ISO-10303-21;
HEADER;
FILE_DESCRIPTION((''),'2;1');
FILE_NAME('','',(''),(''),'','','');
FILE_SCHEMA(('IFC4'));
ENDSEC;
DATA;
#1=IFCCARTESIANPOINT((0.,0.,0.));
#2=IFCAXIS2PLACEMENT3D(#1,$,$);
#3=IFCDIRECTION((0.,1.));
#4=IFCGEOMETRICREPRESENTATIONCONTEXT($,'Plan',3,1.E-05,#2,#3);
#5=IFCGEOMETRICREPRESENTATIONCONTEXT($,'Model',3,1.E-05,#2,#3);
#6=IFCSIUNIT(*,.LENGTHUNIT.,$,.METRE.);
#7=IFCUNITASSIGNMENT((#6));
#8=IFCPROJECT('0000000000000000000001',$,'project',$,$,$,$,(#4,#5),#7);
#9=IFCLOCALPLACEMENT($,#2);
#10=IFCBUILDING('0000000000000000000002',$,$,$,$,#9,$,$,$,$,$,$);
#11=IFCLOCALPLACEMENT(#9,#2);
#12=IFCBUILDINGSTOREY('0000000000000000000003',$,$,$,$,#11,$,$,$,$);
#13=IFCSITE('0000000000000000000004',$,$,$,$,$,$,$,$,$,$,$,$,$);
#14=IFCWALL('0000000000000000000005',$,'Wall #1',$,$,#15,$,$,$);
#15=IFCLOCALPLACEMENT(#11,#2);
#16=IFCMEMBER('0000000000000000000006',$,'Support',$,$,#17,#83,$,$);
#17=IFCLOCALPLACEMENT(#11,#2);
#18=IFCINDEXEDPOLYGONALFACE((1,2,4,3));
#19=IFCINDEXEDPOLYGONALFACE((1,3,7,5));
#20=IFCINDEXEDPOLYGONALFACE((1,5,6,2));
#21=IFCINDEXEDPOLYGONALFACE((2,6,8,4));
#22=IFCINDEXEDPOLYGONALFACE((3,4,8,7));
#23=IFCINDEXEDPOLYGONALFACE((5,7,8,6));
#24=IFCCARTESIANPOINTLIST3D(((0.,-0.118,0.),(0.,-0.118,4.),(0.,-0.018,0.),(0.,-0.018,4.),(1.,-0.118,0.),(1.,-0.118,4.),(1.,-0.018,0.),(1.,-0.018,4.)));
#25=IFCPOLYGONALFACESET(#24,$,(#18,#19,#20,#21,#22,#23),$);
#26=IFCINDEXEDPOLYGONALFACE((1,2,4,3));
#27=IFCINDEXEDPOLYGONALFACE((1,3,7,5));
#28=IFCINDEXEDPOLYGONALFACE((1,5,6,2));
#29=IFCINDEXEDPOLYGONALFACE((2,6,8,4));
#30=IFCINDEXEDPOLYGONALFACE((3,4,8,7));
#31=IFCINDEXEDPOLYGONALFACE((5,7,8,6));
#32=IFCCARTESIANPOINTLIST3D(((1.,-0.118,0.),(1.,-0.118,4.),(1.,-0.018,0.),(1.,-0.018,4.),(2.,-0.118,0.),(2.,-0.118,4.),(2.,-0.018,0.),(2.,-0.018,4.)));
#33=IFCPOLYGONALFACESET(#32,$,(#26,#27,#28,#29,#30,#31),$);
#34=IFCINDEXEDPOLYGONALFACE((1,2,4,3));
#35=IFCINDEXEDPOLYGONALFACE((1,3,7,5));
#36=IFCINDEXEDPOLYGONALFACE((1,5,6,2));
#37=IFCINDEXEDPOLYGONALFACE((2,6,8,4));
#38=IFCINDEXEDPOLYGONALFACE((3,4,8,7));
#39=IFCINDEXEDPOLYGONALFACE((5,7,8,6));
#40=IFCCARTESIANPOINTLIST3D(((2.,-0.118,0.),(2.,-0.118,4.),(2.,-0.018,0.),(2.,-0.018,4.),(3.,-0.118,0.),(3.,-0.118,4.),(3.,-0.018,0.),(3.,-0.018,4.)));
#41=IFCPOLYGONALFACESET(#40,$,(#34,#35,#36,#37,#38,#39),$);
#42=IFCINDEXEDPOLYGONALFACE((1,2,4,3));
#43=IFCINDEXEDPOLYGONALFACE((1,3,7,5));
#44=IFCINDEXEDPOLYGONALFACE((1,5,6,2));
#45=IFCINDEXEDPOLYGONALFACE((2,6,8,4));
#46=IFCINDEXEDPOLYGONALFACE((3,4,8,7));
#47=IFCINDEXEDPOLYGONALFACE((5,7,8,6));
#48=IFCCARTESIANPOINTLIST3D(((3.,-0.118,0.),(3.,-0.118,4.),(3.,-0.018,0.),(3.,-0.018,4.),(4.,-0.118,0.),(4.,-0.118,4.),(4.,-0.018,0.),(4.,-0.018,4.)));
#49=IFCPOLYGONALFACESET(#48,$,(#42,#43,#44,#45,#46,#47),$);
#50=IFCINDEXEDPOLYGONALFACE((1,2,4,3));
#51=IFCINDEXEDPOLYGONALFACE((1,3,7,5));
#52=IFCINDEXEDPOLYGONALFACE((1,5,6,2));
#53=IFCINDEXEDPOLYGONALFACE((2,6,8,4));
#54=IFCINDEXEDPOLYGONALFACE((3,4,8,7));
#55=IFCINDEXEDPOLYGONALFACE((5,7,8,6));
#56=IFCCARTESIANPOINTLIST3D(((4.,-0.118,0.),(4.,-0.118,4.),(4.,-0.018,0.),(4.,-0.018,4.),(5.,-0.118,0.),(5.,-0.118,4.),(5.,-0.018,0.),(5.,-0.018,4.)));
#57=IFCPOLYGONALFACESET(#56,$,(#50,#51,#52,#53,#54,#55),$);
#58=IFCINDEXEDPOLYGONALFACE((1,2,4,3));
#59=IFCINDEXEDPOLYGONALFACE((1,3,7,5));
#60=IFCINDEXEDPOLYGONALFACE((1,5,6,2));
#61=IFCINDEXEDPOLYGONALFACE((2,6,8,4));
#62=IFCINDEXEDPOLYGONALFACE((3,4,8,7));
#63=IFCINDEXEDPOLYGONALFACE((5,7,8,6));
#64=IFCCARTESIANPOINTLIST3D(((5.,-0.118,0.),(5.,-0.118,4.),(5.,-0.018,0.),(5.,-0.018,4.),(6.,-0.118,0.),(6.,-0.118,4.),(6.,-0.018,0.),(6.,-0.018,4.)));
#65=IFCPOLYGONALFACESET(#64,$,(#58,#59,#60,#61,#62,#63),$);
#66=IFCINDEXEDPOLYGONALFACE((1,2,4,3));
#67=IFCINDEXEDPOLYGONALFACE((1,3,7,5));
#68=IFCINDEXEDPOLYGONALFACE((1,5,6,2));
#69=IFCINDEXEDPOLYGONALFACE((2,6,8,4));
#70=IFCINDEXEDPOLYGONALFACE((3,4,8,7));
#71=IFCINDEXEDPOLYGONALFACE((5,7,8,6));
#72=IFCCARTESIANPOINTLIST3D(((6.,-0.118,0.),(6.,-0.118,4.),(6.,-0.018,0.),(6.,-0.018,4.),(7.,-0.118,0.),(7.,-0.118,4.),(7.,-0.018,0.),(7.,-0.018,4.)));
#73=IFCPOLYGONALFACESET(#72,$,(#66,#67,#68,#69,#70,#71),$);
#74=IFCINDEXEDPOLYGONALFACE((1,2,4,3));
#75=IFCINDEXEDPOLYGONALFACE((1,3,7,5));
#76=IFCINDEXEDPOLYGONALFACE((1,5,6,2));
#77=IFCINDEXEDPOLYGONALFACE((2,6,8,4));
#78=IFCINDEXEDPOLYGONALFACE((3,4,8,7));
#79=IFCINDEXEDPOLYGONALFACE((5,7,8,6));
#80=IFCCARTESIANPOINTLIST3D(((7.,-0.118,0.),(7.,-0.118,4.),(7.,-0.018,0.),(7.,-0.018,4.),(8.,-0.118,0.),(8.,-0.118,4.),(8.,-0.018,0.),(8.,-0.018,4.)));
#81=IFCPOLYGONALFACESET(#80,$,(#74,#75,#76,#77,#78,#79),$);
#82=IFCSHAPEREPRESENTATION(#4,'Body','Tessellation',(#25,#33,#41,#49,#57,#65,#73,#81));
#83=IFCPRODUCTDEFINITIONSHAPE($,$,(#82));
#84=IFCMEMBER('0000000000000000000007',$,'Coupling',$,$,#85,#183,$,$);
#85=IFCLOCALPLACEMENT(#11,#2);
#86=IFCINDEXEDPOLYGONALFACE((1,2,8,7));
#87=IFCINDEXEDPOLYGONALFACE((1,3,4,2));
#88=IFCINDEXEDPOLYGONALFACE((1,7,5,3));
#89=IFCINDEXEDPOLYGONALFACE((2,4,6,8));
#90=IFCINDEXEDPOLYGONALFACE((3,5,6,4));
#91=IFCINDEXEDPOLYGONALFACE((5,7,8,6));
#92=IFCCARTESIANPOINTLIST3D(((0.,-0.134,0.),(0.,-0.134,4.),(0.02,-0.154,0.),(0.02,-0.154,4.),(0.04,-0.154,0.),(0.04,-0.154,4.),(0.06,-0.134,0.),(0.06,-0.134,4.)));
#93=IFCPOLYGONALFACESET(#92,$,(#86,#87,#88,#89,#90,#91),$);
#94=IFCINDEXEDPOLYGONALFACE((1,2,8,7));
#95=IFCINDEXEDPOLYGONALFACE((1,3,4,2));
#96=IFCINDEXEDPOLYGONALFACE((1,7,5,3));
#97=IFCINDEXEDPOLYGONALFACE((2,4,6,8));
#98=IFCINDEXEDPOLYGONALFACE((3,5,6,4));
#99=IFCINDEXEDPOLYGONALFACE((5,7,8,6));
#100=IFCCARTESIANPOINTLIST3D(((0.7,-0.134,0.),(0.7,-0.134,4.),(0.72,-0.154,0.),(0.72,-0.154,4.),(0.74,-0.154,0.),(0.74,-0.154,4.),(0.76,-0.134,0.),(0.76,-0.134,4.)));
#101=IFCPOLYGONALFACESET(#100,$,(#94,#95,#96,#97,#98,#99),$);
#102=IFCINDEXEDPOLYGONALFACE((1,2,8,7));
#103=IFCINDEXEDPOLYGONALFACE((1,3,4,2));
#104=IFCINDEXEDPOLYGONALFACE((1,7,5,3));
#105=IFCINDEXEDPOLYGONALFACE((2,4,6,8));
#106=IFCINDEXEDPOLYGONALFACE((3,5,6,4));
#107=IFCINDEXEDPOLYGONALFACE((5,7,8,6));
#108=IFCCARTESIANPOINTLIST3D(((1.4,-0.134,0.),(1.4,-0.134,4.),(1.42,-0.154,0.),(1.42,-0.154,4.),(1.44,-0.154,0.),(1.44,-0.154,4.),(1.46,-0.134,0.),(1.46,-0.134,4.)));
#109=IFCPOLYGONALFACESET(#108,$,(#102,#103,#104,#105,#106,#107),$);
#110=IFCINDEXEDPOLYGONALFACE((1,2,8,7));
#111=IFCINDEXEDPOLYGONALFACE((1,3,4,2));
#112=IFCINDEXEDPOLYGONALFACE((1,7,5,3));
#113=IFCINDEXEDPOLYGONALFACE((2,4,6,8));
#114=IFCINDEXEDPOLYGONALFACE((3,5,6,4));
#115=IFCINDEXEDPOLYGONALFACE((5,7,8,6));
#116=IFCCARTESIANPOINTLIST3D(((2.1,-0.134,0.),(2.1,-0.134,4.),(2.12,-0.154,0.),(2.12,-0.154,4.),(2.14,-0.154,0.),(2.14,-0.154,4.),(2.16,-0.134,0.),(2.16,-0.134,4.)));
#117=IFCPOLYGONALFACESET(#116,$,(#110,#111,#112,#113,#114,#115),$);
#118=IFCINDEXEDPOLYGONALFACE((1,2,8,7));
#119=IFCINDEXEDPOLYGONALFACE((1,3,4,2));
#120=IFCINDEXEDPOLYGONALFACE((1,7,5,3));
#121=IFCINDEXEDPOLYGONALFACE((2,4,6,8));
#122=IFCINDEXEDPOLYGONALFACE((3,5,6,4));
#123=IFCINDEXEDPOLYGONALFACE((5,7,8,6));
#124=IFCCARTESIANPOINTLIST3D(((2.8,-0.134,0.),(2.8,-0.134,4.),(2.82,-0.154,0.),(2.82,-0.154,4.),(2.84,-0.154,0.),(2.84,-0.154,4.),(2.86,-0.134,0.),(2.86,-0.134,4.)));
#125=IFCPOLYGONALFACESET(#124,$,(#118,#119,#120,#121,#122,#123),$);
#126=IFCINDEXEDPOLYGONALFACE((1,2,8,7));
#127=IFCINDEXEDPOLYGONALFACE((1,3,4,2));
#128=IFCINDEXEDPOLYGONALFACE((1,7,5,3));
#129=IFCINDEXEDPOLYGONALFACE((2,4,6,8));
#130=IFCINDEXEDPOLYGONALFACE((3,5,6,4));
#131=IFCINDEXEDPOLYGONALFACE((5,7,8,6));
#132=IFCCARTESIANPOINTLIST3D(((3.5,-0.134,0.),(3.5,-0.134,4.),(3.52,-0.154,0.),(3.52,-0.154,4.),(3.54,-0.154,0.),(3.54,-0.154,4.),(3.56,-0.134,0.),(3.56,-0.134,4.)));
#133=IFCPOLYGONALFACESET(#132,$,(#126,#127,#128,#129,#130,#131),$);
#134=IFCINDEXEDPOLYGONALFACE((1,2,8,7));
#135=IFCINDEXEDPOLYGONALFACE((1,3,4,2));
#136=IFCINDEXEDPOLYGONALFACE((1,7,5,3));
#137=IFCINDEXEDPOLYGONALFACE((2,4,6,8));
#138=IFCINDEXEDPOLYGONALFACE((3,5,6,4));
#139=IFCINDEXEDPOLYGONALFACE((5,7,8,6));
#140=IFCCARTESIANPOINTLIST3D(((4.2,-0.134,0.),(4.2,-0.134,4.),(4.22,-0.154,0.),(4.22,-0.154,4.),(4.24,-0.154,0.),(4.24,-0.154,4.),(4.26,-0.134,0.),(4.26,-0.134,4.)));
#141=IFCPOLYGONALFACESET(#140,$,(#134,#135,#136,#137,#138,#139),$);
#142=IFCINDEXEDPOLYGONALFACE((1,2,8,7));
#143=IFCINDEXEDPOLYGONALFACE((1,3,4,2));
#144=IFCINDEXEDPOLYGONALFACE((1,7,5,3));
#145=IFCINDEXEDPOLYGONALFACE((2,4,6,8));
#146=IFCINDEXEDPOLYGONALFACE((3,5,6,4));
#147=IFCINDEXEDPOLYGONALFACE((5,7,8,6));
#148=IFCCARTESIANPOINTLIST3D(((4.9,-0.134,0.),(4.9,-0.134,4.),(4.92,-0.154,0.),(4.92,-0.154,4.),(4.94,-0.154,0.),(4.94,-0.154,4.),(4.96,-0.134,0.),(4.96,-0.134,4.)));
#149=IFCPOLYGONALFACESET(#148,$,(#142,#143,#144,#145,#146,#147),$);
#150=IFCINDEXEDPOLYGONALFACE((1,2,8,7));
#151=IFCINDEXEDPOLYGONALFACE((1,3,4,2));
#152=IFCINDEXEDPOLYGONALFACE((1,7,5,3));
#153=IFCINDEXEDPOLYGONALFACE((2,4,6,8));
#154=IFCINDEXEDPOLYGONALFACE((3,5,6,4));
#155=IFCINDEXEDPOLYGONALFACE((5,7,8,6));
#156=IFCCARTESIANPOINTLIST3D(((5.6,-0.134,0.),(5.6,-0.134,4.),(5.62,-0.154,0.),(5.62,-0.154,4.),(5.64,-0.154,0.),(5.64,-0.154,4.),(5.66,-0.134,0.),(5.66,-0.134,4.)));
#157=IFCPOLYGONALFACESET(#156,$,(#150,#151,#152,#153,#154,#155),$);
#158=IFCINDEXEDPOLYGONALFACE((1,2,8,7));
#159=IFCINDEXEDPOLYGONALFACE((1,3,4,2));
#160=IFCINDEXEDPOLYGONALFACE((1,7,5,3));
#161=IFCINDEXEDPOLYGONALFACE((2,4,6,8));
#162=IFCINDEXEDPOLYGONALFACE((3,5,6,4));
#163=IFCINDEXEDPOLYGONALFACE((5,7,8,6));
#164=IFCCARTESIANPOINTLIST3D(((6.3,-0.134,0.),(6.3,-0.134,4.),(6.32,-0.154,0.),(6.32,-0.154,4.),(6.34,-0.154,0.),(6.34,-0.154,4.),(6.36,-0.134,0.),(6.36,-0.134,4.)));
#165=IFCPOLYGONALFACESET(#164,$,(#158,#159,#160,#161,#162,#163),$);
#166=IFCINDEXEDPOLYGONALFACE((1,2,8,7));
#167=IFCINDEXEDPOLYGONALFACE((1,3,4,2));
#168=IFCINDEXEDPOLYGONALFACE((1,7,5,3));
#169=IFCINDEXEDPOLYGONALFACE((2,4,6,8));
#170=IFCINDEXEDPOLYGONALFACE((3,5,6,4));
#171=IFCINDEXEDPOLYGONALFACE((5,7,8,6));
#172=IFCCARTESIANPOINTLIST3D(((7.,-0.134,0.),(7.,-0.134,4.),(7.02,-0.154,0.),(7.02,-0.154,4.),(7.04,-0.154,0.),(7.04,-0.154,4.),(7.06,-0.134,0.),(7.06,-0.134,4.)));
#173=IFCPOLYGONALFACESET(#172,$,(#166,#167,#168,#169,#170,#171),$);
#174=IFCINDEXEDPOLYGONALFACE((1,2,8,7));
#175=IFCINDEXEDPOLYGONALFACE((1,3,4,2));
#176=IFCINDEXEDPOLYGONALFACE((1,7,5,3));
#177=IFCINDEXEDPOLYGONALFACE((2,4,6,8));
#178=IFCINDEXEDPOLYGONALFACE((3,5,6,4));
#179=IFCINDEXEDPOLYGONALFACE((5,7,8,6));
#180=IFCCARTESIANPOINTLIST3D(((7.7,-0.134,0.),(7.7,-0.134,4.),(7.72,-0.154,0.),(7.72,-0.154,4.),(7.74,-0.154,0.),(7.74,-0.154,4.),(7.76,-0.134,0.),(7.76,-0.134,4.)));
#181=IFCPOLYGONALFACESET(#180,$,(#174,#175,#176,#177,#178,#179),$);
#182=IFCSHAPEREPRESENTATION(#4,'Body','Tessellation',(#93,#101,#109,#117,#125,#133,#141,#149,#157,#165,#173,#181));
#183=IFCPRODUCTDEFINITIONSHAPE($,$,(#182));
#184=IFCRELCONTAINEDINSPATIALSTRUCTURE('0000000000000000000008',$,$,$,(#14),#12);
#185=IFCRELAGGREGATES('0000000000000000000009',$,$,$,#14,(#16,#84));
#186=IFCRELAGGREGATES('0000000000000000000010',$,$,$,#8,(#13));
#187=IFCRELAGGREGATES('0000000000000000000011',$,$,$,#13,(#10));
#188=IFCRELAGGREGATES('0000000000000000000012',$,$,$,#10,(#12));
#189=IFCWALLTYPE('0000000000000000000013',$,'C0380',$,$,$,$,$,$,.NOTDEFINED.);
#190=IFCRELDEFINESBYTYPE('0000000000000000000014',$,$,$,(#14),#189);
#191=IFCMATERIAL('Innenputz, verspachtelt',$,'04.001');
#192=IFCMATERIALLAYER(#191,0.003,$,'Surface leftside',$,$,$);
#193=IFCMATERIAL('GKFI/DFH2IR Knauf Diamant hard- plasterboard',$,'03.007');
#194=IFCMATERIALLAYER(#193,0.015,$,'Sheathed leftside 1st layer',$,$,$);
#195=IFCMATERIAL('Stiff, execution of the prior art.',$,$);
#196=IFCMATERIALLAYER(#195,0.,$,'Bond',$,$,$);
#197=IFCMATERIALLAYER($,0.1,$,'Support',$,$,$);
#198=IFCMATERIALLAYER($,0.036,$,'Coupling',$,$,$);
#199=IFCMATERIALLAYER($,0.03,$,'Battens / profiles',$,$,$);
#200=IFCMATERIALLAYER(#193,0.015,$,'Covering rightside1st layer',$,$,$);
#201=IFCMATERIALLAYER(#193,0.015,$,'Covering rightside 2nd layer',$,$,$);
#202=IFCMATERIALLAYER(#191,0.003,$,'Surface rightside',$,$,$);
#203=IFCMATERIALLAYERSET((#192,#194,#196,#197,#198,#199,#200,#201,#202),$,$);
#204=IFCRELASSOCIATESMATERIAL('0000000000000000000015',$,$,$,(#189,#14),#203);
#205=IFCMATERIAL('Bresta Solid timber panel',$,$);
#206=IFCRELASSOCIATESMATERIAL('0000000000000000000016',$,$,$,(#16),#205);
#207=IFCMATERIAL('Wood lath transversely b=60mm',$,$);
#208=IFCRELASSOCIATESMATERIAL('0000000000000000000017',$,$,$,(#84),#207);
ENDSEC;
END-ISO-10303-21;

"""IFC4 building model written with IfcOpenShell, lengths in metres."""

from ifc_helpers import new_model, si_unit, direction, frame, frame_2d, origin, place, context, project, spatial, polyline, rectangle, outline, extrude, material, layer, layer_set, type_object, element, aggregate, save


model = new_model("IFC4")

# Units and contexts
plan_context = context("Plan", 3, precision=1e-05, world=origin(), true_north=direction((0.0, 1.0)))
model_context = context("Model", 3, precision=1e-05, world=origin(), true_north=direction((0.0, 1.0)))
ifc_project = project(units=[si_unit("LENGTHUNIT", "METRE")], contexts=[plan_context, model_context])

# Site, building, storey
site = spatial("IfcSite", under=ifc_project)
building_placement = place(None, origin())
building = spatial("IfcBuilding", under=site, at=building_placement)
storey_placement = place(building_placement, origin())
storey = spatial("IfcBuildingStorey", under=building, at=storey_placement)

# Wall, members
ifc_material_1 = material(Name="Innenputz, verspachtelt", Category="04.001")
ifc_layer_1 = layer(ifc_material_1, 0.003, Name="Surface leftside")
ifc_material_2 = material(Name="GKFI/DFH2IR Knauf Diamant hard- plasterboard", Category="03.007")
ifc_layer_2 = layer(ifc_material_2, 0.015, Name="Sheathed leftside 1st layer")
ifc_material_3 = material(Name="Stiff, execution of the prior art.")
ifc_layer_3 = layer(ifc_material_3, 0.0, Name="Bond")
ifc_layer_4 = layer(None, 0.1, Name="Support")
ifc_layer_5 = layer(None, 0.036, Name="Coupling")
ifc_layer_6 = layer(None, 0.03, Name="Battens / profiles")
ifc_layer_7 = layer(ifc_material_2, 0.015, Name="Covering rightside1st layer")
ifc_layer_8 = layer(ifc_material_2, 0.015, Name="Covering rightside 2nd layer")
ifc_layer_9 = layer(ifc_material_1, 0.003, Name="Surface rightside")
ifc_layer_set = layer_set([ifc_layer_1, ifc_layer_2, ifc_layer_3, ifc_layer_4, ifc_layer_5, ifc_layer_6, ifc_layer_7, ifc_layer_8, ifc_layer_9])
wall_type = type_object("IfcWallType", Name="C0380", PredefinedType="NOTDEFINED", material=ifc_layer_set)
wall_placement = place(None, frame((0.0, 0.0, 0.0), z_axis=(0.0, -1.0, 0.0), x_axis=(1.0, 0.0, 0.0)))
wall = element("IfcWall", 1, at=wall_placement, inside=storey, type_object=wall_type, material=ifc_layer_set, Name="Wall #1")
ifc_material_4 = material(Name="Bresta Solid timber panel")
member_1_placement = place(wall_placement, origin())
member_1 = element("IfcMember", 2, at=member_1_placement, material=ifc_material_4, Name="Support", context=plan_context, shape_type="SweptSolid", body=[
    extrude(rectangle(XDim=1.0, YDim=0.1, at=frame_2d((0.5, 0.05), x_axis=(1.0, 0.0))), frame((0.0, 4.0, 0.018), z_axis=(0.0, -1.0, 0.0), x_axis=(1.0, 0.0, 0.0)), (0.0, 0.0, 1.0), 4.0),
    extrude(rectangle(XDim=1.0, YDim=0.1, at=frame_2d((0.5, 0.05), x_axis=(1.0, 0.0))), frame((1.0, 4.0, 0.018), z_axis=(0.0, -1.0, 0.0), x_axis=(1.0, 0.0, 0.0)), (0.0, 0.0, 1.0), 4.0),
    extrude(rectangle(XDim=1.0, YDim=0.1, at=frame_2d((0.5, 0.05), x_axis=(1.0, 0.0))), frame((2.0, 4.0, 0.018), z_axis=(0.0, -1.0, 0.0), x_axis=(1.0, 0.0, 0.0)), (0.0, 0.0, 1.0), 4.0),
    extrude(rectangle(XDim=1.0, YDim=0.1, at=frame_2d((0.5, 0.05), x_axis=(1.0, 0.0))), frame((3.0, 4.0, 0.018), z_axis=(0.0, -1.0, 0.0), x_axis=(1.0, 0.0, 0.0)), (0.0, 0.0, 1.0), 4.0),
    extrude(rectangle(XDim=1.0, YDim=0.1, at=frame_2d((0.5, 0.05), x_axis=(1.0, 0.0))), frame((4.0, 4.0, 0.018), z_axis=(0.0, -1.0, 0.0), x_axis=(1.0, 0.0, 0.0)), (0.0, 0.0, 1.0), 4.0),
    extrude(rectangle(XDim=1.0, YDim=0.1, at=frame_2d((0.5, 0.05), x_axis=(1.0, 0.0))), frame((5.0, 4.0, 0.018), z_axis=(0.0, -1.0, 0.0), x_axis=(1.0, 0.0, 0.0)), (0.0, 0.0, 1.0), 4.0),
    extrude(rectangle(XDim=1.0, YDim=0.1, at=frame_2d((0.5, 0.05), x_axis=(1.0, 0.0))), frame((6.0, 4.0, 0.018), z_axis=(0.0, -1.0, 0.0), x_axis=(1.0, 0.0, 0.0)), (0.0, 0.0, 1.0), 4.0),
    extrude(rectangle(XDim=1.0, YDim=0.1, at=frame_2d((0.5, 0.05), x_axis=(1.0, 0.0))), frame((7.0, 4.0, 0.018), z_axis=(0.0, -1.0, 0.0), x_axis=(1.0, 0.0, 0.0)), (0.0, 0.0, 1.0), 4.0),
])
ifc_material_5 = material(Name="Wood lath transversely b=60mm")
member_2_placement = place(wall_placement, origin())
member_2 = element("IfcMember", 3, at=member_2_placement, material=ifc_material_5, Name="Coupling", context=plan_context, shape_type="SweptSolid", body=[
    extrude(outline(polyline([(0.0, 0.0), (0.06, 0.0), (0.04, 0.02), (0.02, 0.02), (0.0, 0.0)])), frame((0.0, 4.0, 0.134), z_axis=(0.0, -1.0, 0.0), x_axis=(1.0, 0.0, 0.0)), (0.0, 0.0, 1.0), 4.0),
    extrude(outline(polyline([(0.0, 0.0), (0.06, 0.0), (0.04, 0.02), (0.02, 0.02), (0.0, 0.0)])), frame((0.7, 4.0, 0.134), z_axis=(0.0, -1.0, 0.0), x_axis=(1.0, 0.0, 0.0)), (0.0, 0.0, 1.0), 4.0),
    extrude(outline(polyline([(0.0, 0.0), (0.06, 0.0), (0.04, 0.02), (0.02, 0.02), (0.0, 0.0)])), frame((1.4, 4.0, 0.134), z_axis=(0.0, -1.0, 0.0), x_axis=(1.0, 0.0, 0.0)), (0.0, 0.0, 1.0), 4.0),
    extrude(outline(polyline([(0.0, 0.0), (0.06, 0.0), (0.04, 0.02), (0.02, 0.02), (0.0, 0.0)])), frame((2.1, 4.0, 0.134), z_axis=(0.0, -1.0, 0.0), x_axis=(1.0, 0.0, 0.0)), (0.0, 0.0, 1.0), 4.0),
    extrude(outline(polyline([(0.0, 0.0), (0.06, 0.0), (0.04, 0.02), (0.02, 0.02), (0.0, 0.0)])), frame((2.8, 4.0, 0.134), z_axis=(0.0, -1.0, 0.0), x_axis=(1.0, 0.0, 0.0)), (0.0, 0.0, 1.0), 4.0),
    extrude(outline(polyline([(0.0, 0.0), (0.06, 0.0), (0.04, 0.02), (0.02, 0.02), (0.0, 0.0)])), frame((3.5, 4.0, 0.134), z_axis=(0.0, -1.0, 0.0), x_axis=(1.0, 0.0, 0.0)), (0.0, 0.0, 1.0), 4.0),
    extrude(outline(polyline([(0.0, 0.0), (0.06, 0.0), (0.04, 0.02), (0.02, 0.02), (0.0, 0.0)])), frame((4.2, 4.0, 0.134), z_axis=(0.0, -1.0, 0.0), x_axis=(1.0, 0.0, 0.0)), (0.0, 0.0, 1.0), 4.0),
    extrude(outline(polyline([(0.0, 0.0), (0.06, 0.0), (0.04, 0.02), (0.02, 0.02), (0.0, 0.0)])), frame((4.9, 4.0, 0.134), z_axis=(0.0, -1.0, 0.0), x_axis=(1.0, 0.0, 0.0)), (0.0, 0.0, 1.0), 4.0),
    extrude(outline(polyline([(0.0, 0.0), (0.06, 0.0), (0.04, 0.02), (0.02, 0.02), (0.0, 0.0)])), frame((5.6, 4.0, 0.134), z_axis=(0.0, -1.0, 0.0), x_axis=(1.0, 0.0, 0.0)), (0.0, 0.0, 1.0), 4.0),
    extrude(outline(polyline([(0.0, 0.0), (0.06, 0.0), (0.04, 0.02), (0.02, 0.02), (0.0, 0.0)])), frame((6.3, 4.0, 0.134), z_axis=(0.0, -1.0, 0.0), x_axis=(1.0, 0.0, 0.0)), (0.0, 0.0, 1.0), 4.0),
    extrude(outline(polyline([(0.0, 0.0), (0.06, 0.0), (0.04, 0.02), (0.02, 0.02), (0.0, 0.0)])), frame((7.0, 4.0, 0.134), z_axis=(0.0, -1.0, 0.0), x_axis=(1.0, 0.0, 0.0)), (0.0, 0.0, 1.0), 4.0),
    extrude(outline(polyline([(0.0, 0.0), (0.06, 0.0), (0.04, 0.02), (0.02, 0.02), (0.0, 0.0)])), frame((7.7, 4.0, 0.134), z_axis=(0.0, -1.0, 0.0), x_axis=(1.0, 0.0, 0.0)), (0.0, 0.0, 1.0), 4.0),
])
aggregate(wall, [member_1, member_2])

save(model, "model.ifc")
